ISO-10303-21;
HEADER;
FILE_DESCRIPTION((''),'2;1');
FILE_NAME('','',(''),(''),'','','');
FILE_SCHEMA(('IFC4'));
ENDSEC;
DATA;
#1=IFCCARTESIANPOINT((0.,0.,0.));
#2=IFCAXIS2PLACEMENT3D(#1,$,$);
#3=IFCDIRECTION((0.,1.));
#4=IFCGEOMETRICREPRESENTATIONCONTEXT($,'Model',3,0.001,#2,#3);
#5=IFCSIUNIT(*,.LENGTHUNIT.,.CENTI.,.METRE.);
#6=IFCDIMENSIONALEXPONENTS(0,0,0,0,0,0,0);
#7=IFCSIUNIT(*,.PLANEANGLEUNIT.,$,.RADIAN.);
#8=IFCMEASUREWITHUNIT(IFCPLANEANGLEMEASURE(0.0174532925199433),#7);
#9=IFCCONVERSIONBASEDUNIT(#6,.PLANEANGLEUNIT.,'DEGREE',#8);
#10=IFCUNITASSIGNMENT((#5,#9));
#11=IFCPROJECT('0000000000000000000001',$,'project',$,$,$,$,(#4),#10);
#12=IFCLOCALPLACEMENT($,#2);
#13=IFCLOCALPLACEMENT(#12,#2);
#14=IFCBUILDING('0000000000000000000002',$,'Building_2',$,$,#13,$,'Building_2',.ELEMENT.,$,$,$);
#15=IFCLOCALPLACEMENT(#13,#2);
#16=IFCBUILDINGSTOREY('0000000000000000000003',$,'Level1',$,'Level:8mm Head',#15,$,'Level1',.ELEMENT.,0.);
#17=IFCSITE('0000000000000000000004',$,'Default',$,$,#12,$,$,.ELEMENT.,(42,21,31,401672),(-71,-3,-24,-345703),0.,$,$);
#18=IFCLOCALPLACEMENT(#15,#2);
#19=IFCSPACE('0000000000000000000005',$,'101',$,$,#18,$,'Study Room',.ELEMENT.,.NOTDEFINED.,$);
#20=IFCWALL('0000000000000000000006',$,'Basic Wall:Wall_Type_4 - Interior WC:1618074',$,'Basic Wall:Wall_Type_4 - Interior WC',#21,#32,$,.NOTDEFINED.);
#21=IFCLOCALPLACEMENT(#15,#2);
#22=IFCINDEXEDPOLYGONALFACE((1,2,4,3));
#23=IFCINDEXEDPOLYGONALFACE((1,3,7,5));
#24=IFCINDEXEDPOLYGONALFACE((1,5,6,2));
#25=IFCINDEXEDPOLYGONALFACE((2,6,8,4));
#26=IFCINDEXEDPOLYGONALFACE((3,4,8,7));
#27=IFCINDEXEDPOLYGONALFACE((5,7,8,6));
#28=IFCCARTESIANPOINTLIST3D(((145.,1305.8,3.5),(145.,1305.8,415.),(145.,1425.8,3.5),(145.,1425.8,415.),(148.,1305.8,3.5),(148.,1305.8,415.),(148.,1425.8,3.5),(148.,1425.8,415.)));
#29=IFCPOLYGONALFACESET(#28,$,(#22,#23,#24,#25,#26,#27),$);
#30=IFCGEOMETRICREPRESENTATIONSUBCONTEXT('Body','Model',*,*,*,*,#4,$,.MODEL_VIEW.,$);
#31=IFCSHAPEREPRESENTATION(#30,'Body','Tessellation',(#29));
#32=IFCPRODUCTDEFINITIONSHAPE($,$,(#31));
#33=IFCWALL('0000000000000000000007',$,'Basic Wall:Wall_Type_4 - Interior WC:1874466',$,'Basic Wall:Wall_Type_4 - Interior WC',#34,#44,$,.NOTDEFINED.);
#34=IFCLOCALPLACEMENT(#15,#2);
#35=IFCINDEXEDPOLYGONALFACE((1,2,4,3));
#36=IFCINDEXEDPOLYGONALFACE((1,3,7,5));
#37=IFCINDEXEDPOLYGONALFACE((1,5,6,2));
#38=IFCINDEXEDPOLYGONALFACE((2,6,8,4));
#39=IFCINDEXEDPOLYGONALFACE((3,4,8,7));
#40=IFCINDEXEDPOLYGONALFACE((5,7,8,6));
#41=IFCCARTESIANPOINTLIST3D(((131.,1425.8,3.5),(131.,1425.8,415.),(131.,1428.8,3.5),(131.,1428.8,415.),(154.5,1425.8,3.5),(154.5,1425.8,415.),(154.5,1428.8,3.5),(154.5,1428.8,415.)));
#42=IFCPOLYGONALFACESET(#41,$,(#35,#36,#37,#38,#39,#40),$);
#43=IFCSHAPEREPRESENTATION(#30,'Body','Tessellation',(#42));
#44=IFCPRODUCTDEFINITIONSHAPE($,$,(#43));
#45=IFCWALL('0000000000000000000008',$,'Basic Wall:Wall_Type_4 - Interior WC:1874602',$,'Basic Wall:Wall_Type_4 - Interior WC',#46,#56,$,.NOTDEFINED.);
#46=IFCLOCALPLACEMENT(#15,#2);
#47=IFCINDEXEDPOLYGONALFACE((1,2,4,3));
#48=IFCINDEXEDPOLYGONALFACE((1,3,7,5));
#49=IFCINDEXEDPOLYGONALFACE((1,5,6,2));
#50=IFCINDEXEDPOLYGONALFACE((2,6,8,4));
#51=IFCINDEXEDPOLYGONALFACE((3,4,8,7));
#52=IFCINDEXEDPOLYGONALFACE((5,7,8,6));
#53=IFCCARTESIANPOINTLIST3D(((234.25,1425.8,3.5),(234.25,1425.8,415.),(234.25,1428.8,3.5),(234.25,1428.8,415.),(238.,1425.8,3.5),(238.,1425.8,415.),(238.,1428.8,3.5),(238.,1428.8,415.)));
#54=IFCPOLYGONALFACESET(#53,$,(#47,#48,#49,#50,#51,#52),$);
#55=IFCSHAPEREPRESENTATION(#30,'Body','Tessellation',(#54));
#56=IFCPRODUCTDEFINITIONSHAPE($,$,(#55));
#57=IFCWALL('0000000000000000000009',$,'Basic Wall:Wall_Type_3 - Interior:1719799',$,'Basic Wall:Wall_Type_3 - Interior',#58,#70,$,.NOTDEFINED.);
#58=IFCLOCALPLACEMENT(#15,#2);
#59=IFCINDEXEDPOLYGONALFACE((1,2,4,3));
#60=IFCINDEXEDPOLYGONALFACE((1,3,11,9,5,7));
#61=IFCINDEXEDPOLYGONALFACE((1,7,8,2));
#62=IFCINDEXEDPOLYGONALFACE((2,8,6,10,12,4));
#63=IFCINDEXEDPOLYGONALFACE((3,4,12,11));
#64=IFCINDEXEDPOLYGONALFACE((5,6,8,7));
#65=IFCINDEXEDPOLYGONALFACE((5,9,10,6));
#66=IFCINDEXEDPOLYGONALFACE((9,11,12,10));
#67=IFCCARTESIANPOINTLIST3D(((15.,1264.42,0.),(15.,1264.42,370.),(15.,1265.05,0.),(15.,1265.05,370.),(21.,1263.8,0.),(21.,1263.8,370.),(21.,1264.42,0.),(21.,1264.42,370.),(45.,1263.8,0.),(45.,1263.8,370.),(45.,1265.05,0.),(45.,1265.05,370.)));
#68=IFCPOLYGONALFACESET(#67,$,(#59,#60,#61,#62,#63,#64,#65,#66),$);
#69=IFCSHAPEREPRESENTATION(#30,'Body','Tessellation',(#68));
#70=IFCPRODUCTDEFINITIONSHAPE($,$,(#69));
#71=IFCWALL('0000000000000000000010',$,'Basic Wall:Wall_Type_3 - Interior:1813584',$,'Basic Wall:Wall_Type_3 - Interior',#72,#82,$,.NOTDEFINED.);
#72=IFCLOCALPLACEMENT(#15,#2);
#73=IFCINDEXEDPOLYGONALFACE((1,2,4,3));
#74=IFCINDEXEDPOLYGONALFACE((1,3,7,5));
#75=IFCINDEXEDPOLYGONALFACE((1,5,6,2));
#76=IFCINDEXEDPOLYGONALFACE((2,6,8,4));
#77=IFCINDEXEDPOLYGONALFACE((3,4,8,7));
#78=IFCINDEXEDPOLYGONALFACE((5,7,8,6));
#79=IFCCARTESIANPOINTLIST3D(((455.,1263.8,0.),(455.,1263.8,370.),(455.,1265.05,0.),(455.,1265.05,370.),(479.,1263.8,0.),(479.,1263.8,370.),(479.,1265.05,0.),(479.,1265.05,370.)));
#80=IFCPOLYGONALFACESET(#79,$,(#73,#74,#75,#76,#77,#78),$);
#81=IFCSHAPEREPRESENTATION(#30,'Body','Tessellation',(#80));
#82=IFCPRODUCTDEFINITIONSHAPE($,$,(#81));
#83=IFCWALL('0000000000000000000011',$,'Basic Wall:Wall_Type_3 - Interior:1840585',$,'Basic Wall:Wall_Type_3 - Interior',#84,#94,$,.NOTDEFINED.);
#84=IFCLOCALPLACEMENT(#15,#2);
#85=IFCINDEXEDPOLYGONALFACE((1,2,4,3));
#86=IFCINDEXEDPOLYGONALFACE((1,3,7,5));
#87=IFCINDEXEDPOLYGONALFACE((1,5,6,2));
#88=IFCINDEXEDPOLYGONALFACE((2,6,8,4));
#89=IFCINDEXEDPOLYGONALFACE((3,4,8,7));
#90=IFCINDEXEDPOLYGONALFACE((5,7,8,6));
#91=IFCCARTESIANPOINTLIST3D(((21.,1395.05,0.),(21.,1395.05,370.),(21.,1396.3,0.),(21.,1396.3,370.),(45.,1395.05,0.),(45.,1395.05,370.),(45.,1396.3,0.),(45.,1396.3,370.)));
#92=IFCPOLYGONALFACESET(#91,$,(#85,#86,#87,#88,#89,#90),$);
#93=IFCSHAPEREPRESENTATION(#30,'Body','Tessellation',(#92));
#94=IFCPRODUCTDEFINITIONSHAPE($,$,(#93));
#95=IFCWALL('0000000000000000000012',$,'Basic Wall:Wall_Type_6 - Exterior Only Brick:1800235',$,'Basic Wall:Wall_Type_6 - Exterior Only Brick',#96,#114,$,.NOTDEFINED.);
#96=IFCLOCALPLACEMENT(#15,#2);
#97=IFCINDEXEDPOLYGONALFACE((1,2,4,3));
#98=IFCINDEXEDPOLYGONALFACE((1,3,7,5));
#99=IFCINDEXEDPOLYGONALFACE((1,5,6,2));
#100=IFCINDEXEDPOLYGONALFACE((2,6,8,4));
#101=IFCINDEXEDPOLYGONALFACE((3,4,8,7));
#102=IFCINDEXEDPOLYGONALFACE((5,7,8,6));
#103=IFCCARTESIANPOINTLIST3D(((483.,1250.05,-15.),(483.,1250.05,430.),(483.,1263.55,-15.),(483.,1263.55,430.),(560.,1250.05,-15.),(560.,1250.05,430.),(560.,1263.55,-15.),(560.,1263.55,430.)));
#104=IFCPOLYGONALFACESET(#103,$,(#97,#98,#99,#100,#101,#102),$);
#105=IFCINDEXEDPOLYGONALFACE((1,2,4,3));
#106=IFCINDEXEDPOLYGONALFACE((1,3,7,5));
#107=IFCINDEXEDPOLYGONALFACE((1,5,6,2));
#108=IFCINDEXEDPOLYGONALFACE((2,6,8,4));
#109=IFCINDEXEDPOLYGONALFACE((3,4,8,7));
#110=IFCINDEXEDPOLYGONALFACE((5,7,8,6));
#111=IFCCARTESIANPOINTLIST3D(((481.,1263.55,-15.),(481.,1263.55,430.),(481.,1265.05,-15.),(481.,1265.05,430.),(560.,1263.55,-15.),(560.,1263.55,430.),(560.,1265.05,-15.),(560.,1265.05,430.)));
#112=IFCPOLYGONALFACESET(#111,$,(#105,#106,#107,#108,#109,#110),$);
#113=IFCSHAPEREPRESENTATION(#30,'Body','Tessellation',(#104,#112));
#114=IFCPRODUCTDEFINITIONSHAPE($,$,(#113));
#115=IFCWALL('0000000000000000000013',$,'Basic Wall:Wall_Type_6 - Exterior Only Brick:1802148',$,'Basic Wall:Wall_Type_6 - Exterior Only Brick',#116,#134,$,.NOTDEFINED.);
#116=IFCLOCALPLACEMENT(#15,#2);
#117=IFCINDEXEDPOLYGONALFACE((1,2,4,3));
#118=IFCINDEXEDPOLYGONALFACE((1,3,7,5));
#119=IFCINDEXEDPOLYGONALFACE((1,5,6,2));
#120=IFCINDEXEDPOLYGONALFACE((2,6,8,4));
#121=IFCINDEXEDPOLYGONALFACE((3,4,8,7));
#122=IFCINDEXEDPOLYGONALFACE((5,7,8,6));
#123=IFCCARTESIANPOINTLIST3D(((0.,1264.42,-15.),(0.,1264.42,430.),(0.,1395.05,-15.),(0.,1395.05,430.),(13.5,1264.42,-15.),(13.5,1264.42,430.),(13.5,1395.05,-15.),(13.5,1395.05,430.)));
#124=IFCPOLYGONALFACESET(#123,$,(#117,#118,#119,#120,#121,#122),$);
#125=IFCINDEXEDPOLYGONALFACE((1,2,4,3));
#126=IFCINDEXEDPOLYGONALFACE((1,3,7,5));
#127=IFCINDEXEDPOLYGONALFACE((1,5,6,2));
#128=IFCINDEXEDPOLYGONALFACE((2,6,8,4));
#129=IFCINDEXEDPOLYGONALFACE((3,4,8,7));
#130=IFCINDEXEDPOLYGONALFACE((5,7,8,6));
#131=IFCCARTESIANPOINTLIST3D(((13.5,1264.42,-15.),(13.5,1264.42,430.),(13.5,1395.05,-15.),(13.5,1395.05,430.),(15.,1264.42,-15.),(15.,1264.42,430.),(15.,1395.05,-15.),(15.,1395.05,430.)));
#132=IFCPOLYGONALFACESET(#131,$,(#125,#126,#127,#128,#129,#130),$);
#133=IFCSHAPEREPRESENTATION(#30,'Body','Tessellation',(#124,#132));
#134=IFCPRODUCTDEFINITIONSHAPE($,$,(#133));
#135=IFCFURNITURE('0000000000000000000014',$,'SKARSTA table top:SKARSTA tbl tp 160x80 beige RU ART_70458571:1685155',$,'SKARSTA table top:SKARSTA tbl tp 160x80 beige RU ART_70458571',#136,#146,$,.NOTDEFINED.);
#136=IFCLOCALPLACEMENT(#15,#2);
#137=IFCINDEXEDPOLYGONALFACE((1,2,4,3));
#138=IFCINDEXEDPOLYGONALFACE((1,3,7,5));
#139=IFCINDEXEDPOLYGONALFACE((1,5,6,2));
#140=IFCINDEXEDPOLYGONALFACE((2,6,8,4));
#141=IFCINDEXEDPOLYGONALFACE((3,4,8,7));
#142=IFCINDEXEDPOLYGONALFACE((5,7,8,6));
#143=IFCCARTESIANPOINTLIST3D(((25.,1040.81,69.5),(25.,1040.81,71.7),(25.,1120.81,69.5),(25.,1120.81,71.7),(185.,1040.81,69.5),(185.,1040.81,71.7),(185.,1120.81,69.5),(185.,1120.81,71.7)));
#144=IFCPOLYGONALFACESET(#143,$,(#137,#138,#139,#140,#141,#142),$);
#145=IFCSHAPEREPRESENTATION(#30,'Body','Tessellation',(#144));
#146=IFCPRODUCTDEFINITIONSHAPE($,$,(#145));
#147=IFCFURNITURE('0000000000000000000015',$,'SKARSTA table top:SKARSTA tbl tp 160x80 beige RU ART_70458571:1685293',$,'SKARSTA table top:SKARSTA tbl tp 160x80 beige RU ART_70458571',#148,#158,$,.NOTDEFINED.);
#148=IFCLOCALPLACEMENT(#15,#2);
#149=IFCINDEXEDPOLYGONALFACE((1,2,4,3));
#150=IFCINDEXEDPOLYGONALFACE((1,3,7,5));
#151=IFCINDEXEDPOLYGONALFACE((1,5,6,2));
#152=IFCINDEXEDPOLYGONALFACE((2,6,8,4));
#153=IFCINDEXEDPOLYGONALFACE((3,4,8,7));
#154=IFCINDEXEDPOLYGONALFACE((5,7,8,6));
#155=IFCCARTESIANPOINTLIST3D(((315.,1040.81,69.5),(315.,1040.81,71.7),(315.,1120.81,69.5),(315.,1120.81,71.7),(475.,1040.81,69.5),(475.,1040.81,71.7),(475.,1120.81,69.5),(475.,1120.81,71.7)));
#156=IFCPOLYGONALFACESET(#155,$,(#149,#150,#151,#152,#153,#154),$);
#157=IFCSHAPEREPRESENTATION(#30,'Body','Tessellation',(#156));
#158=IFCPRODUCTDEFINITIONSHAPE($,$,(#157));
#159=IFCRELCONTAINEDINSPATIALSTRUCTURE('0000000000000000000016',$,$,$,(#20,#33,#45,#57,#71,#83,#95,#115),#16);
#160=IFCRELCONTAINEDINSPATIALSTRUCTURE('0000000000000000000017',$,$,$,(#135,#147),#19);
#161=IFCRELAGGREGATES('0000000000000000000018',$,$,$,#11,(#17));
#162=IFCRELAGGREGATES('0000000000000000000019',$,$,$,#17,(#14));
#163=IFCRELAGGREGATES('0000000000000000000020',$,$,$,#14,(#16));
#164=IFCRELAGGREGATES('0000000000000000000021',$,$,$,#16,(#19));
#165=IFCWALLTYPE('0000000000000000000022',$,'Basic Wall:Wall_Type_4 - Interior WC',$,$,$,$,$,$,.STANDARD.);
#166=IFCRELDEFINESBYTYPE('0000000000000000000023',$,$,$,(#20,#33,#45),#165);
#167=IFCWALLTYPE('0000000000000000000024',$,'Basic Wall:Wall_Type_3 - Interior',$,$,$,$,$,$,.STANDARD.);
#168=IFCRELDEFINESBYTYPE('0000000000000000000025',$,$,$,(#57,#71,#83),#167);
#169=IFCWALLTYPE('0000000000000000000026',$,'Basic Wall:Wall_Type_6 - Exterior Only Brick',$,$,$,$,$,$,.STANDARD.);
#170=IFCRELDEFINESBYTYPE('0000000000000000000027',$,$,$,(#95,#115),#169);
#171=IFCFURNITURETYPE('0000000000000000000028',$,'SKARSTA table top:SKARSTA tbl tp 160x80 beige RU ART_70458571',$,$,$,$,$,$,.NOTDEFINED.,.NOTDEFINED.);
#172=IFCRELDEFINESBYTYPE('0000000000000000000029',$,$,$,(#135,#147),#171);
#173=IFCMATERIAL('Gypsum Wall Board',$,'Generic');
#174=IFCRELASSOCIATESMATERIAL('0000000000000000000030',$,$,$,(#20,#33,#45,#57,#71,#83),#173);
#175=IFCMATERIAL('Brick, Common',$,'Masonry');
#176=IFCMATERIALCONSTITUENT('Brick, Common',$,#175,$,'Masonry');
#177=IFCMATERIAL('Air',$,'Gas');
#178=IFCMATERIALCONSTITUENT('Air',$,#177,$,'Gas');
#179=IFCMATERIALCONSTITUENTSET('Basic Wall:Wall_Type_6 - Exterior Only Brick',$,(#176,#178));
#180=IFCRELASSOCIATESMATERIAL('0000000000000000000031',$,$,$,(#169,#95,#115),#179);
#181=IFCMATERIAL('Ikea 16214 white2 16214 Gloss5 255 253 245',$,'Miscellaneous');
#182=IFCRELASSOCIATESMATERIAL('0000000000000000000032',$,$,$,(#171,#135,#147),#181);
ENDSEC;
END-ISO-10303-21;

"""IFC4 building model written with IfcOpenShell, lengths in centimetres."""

from ifc_helpers import new_model, entity, si_unit, converted_unit, direction, frame, origin, place, context, subcontext, project, spatial, indexed_curve, outline, extrude, source, transform, mapped, material, constituent, constituent_set, type_object, type_shapes, element, save


model = new_model("IFC4")

# Units and contexts
model_context = context("Model", 3, precision=0.001, world=origin(), true_north=direction((0.0, 1.0)))
body_context = subcontext(model_context, "Body", "Model", "MODEL_VIEW")
ifc_project = project(units=[si_unit("LENGTHUNIT", "METRE", prefix="CENTI"), converted_unit("PLANEANGLEUNIT", "DEGREE", entity("IfcPlaneAngleMeasure", 0.0174532925199433), si_unit("PLANEANGLEUNIT", "RADIAN"), dimensions=[0, 0, 0, 0, 0, 0, 0])], contexts=[model_context])

# Site, building, storey
site_placement = place(None, origin())
site = spatial("IfcSite", under=ifc_project, at=site_placement, Name="Default", CompositionType="ELEMENT", RefLatitude=(42, 21, 31, 401672), RefLongitude=(-71, -3, -24, -345703), RefElevation=0.0)
building_placement = place(site_placement, origin())
building = spatial("IfcBuilding", under=site, at=building_placement, Name="Building_2", LongName="Building_2", CompositionType="ELEMENT")
storey_placement = place(building_placement, origin())
storey = spatial("IfcBuildingStorey", under=building, at=storey_placement, Name="Level1", ObjectType="Level:8mm Head", LongName="Level1", CompositionType="ELEMENT", Elevation=0.0)

# Shared definitions
ifc_material_1 = material(Name="Brick, Common", Category="Masonry")
ifc_material_2 = material(Name="Air", Category="Gas")
ifc_material_3 = material(Name="Gypsum Wall Board", Category="Generic")

# Walls
wall_type_1 = type_object("IfcWallType", Name="Basic Wall:Wall_Type_4 - Interior WC", PredefinedType="STANDARD")
wall_1_placement = place(storey_placement, frame((146.5, 1425.8, 3.5), z_axis=(0.0, 0.0, 1.0), x_axis=(0.0, -1.0, 0.0)))
element("IfcWall", 1, at=wall_1_placement, inside=storey, type_object=wall_type_1, material=ifc_material_3, Name="Basic Wall:Wall_Type_4 - Interior WC:1618074", ObjectType="Basic Wall:Wall_Type_4 - Interior WC", PredefinedType="NOTDEFINED", context=body_context, shape_type="SweptSolid", body=[
    extrude(outline(indexed_curve([(120.0, 1.5), (0.0, 1.5), (0.0, -1.5), (120.0, -1.5), (120.0, 1.5)], self_intersect=False)), origin(), (0.0, 0.0, 1.0), 411.5),
])
wall_2_placement = place(storey_placement, frame((131.0, 1427.3, 3.5)))
element("IfcWall", 2, at=wall_2_placement, inside=storey, type_object=wall_type_1, material=ifc_material_3, Name="Basic Wall:Wall_Type_4 - Interior WC:1874466", ObjectType="Basic Wall:Wall_Type_4 - Interior WC", PredefinedType="NOTDEFINED", context=body_context, shape_type="SweptSolid", body=[
    extrude(outline(indexed_curve([(23.5, 1.5), (0.0, 1.5), (0.0, -1.5), (23.5, -1.5), (23.5, 1.5)], self_intersect=False)), origin(), (0.0, 0.0, 1.0), 411.5),
])
wall_3_placement = place(storey_placement, frame((234.25, 1427.3, 3.5)))
element("IfcWall", 3, at=wall_3_placement, inside=storey, type_object=wall_type_1, material=ifc_material_3, Name="Basic Wall:Wall_Type_4 - Interior WC:1874602", ObjectType="Basic Wall:Wall_Type_4 - Interior WC", PredefinedType="NOTDEFINED", context=body_context, shape_type="SweptSolid", body=[
    extrude(outline(indexed_curve([(3.75, 1.5), (0.0, 1.5), (0.0, -1.5), (3.75, -1.5), (3.75, 1.5)], self_intersect=False)), origin(), (0.0, 0.0, 1.0), 411.5),
])
wall_type_2 = type_object("IfcWallType", Name="Basic Wall:Wall_Type_3 - Interior", PredefinedType="STANDARD")
wall_4_placement = place(storey_placement, frame((15.0, 1264.42, 0.0)))
element("IfcWall", 4, at=wall_4_placement, inside=storey, type_object=wall_type_2, material=ifc_material_3, Name="Basic Wall:Wall_Type_3 - Interior:1719799", ObjectType="Basic Wall:Wall_Type_3 - Interior", PredefinedType="NOTDEFINED", context=body_context, shape_type="SweptSolid", body=[
    extrude(outline(indexed_curve([(-0.62, -18.0), (0.63, -18.0), (0.63, 12.0), (0.0, 12.0), (0.0, 6.0), (-0.62, 6.0), (-0.62, -18.0)], self_intersect=False)), frame((12.0, 0.0, 0.0), z_axis=(0.0, 0.0, 1.0), x_axis=(0.0, 1.0, 0.0)), (0.0, 0.0, 1.0), 370.0),
])
wall_5_placement = place(storey_placement, frame((455.0, 1264.42, 0.0)))
element("IfcWall", 5, at=wall_5_placement, inside=storey, type_object=wall_type_2, material=ifc_material_3, Name="Basic Wall:Wall_Type_3 - Interior:1813584", ObjectType="Basic Wall:Wall_Type_3 - Interior", PredefinedType="NOTDEFINED", context=body_context, shape_type="SweptSolid", body=[
    extrude(outline(indexed_curve([(24.0, 0.63), (0.0, 0.63), (0.0, -0.63), (24.0, -0.63), (24.0, 0.63)], self_intersect=False)), origin(), (0.0, 0.0, 1.0), 370.0),
])
wall_6_placement = place(storey_placement, frame((45.0, 1395.67, 0.0), z_axis=(0.0, 0.0, 1.0), x_axis=(-1.0, 0.0, 0.0)))
element("IfcWall", 6, at=wall_6_placement, inside=storey, type_object=wall_type_2, material=ifc_material_3, Name="Basic Wall:Wall_Type_3 - Interior:1840585", ObjectType="Basic Wall:Wall_Type_3 - Interior", PredefinedType="NOTDEFINED", context=body_context, shape_type="SweptSolid", body=[
    extrude(outline(indexed_curve([(24.0, 0.63), (0.0, 0.63), (0.0, -0.63), (24.0, -0.63), (24.0, 0.63)], self_intersect=False)), origin(), (0.0, 0.0, 1.0), 370.0),
])
ifc_constituent_1 = constituent(ifc_material_1, Name="Brick, Common", Category="Masonry")
ifc_constituent_2 = constituent(ifc_material_2, Name="Air", Category="Gas")
ifc_constituent_set_1 = constituent_set(constituents=[ifc_constituent_1, ifc_constituent_2], Name="Basic Wall:Wall_Type_6 - Exterior Only Brick")
wall_type_3 = type_object("IfcWallType", Name="Basic Wall:Wall_Type_6 - Exterior Only Brick", PredefinedType="STANDARD", material=ifc_constituent_set_1)
wall_7_placement = place(storey_placement, frame((560.0, 1257.55, -15.0), z_axis=(0.0, 0.0, 1.0), x_axis=(-1.0, 0.0, 0.0)))
element("IfcWall", 7, at=wall_7_placement, inside=storey, type_object=wall_type_3, material=ifc_constituent_set_1, Name="Basic Wall:Wall_Type_6 - Exterior Only Brick:1800235", ObjectType="Basic Wall:Wall_Type_6 - Exterior Only Brick", PredefinedType="NOTDEFINED", context=body_context, shape_type="SweptSolid", body=[
    extrude(outline(indexed_curve([(-6.75, -38.5), (6.75, -38.5), (6.75, 38.5), (-6.75, 38.5), (-6.75, -38.5)], self_intersect=False)), frame((38.5, 0.75, 0.0), z_axis=(0.0, 0.0, 1.0), x_axis=(0.0, -1.0, 0.0)), (0.0, 0.0, 1.0), 445.0),
    extrude(outline(indexed_curve([(-0.75, -39.5), (0.75, -39.5), (0.75, 39.5), (-0.75, 39.5), (-0.75, -39.5)], self_intersect=False)), frame((39.5, -6.75, 0.0), z_axis=(0.0, 0.0, 1.0), x_axis=(0.0, -1.0, 0.0)), (0.0, 0.0, 1.0), 445.0),
])
wall_8_placement = place(storey_placement, frame((7.5, 1264.42, -15.0), z_axis=(0.0, 0.0, 1.0), x_axis=(0.0, 1.0, 0.0)))
element("IfcWall", 8, at=wall_8_placement, inside=storey, type_object=wall_type_3, material=ifc_constituent_set_1, Name="Basic Wall:Wall_Type_6 - Exterior Only Brick:1802148", ObjectType="Basic Wall:Wall_Type_6 - Exterior Only Brick", PredefinedType="NOTDEFINED", context=body_context, shape_type="SweptSolid", body=[
    extrude(outline(indexed_curve([(-6.75, -65.31), (6.75, -65.31), (6.75, 65.31), (-6.75, 65.31), (-6.75, -65.31)], self_intersect=False)), frame((65.31, 0.75, 0.0), z_axis=(0.0, 0.0, 1.0), x_axis=(0.0, -1.0, 0.0)), (0.0, 0.0, 1.0), 445.0),
    extrude(outline(indexed_curve([(-0.75, -65.31), (0.75, -65.31), (0.75, 65.31), (-0.75, 65.31), (-0.75, -65.31)], self_intersect=False)), frame((65.31, -6.75, 0.0), z_axis=(0.0, 0.0, 1.0), x_axis=(0.0, -1.0, 0.0)), (0.0, 0.0, 1.0), 445.0),
])

# Shared definitions
space_1_placement = place(storey_placement, origin())
space_1 = spatial("IfcSpace", under=storey, at=space_1_placement, Name="101", LongName="Study Room", CompositionType="ELEMENT", PredefinedType="NOTDEFINED")

# Furniture
ifc_material_4 = material(Name="Ikea 16214 white2 16214 Gloss5 255 253 245", Category="Miscellaneous")
furniture_type = type_object("IfcFurnitureType", Name="SKARSTA table top:SKARSTA tbl tp 160x80 beige RU ART_70458571", AssemblyPlace="NOTDEFINED", PredefinedType="NOTDEFINED", material=ifc_material_4)
shared_shape_1 = source(origin(), body_context, "Body", "SweptSolid", [
    extrude(outline(indexed_curve([(-80.0, -40.0), (80.0, -40.0), (80.0, 40.0), (-80.0, 40.0), (-80.0, -40.0)], self_intersect=False)), frame((0.0, 0.0, 0.0), z_axis=(0.0, 0.0, 1.0), x_axis=(-1.0, 0.0, 0.0)), (0.0, 0.0, 1.0), 2.2),
])
type_shapes(furniture_type, [shared_shape_1])
for number, where, z_axis, x_axis, name in (
    (9, (105.0, 1080.81, 69.5), (0.0, 0.0, 1.0), (-1.0, 0.0, 0.0), "SKARSTA table top:SKARSTA tbl tp 160x80 beige RU ART_70458571:1685155"),
    (10, (395.0, 1080.81, 69.5), (0.0, 0.0, 1.0), (-1.0, 0.0, 0.0), "SKARSTA table top:SKARSTA tbl tp 160x80 beige RU ART_70458571:1685293"),
):
    element("IfcFurniture", number, at=place(space_1_placement, frame(where, z_axis=z_axis, x_axis=x_axis)), inside=space_1, type_object=furniture_type, material=ifc_material_4, Name=name, ObjectType="SKARSTA table top:SKARSTA tbl tp 160x80 beige RU ART_70458571", PredefinedType="NOTDEFINED", context=body_context, shape_type="MappedRepresentation", body=[
        mapped(shared_shape_1, transform((0.0, 0.0, 0.0), scale=1.0)),
    ])

save(model, "model.ifc")
